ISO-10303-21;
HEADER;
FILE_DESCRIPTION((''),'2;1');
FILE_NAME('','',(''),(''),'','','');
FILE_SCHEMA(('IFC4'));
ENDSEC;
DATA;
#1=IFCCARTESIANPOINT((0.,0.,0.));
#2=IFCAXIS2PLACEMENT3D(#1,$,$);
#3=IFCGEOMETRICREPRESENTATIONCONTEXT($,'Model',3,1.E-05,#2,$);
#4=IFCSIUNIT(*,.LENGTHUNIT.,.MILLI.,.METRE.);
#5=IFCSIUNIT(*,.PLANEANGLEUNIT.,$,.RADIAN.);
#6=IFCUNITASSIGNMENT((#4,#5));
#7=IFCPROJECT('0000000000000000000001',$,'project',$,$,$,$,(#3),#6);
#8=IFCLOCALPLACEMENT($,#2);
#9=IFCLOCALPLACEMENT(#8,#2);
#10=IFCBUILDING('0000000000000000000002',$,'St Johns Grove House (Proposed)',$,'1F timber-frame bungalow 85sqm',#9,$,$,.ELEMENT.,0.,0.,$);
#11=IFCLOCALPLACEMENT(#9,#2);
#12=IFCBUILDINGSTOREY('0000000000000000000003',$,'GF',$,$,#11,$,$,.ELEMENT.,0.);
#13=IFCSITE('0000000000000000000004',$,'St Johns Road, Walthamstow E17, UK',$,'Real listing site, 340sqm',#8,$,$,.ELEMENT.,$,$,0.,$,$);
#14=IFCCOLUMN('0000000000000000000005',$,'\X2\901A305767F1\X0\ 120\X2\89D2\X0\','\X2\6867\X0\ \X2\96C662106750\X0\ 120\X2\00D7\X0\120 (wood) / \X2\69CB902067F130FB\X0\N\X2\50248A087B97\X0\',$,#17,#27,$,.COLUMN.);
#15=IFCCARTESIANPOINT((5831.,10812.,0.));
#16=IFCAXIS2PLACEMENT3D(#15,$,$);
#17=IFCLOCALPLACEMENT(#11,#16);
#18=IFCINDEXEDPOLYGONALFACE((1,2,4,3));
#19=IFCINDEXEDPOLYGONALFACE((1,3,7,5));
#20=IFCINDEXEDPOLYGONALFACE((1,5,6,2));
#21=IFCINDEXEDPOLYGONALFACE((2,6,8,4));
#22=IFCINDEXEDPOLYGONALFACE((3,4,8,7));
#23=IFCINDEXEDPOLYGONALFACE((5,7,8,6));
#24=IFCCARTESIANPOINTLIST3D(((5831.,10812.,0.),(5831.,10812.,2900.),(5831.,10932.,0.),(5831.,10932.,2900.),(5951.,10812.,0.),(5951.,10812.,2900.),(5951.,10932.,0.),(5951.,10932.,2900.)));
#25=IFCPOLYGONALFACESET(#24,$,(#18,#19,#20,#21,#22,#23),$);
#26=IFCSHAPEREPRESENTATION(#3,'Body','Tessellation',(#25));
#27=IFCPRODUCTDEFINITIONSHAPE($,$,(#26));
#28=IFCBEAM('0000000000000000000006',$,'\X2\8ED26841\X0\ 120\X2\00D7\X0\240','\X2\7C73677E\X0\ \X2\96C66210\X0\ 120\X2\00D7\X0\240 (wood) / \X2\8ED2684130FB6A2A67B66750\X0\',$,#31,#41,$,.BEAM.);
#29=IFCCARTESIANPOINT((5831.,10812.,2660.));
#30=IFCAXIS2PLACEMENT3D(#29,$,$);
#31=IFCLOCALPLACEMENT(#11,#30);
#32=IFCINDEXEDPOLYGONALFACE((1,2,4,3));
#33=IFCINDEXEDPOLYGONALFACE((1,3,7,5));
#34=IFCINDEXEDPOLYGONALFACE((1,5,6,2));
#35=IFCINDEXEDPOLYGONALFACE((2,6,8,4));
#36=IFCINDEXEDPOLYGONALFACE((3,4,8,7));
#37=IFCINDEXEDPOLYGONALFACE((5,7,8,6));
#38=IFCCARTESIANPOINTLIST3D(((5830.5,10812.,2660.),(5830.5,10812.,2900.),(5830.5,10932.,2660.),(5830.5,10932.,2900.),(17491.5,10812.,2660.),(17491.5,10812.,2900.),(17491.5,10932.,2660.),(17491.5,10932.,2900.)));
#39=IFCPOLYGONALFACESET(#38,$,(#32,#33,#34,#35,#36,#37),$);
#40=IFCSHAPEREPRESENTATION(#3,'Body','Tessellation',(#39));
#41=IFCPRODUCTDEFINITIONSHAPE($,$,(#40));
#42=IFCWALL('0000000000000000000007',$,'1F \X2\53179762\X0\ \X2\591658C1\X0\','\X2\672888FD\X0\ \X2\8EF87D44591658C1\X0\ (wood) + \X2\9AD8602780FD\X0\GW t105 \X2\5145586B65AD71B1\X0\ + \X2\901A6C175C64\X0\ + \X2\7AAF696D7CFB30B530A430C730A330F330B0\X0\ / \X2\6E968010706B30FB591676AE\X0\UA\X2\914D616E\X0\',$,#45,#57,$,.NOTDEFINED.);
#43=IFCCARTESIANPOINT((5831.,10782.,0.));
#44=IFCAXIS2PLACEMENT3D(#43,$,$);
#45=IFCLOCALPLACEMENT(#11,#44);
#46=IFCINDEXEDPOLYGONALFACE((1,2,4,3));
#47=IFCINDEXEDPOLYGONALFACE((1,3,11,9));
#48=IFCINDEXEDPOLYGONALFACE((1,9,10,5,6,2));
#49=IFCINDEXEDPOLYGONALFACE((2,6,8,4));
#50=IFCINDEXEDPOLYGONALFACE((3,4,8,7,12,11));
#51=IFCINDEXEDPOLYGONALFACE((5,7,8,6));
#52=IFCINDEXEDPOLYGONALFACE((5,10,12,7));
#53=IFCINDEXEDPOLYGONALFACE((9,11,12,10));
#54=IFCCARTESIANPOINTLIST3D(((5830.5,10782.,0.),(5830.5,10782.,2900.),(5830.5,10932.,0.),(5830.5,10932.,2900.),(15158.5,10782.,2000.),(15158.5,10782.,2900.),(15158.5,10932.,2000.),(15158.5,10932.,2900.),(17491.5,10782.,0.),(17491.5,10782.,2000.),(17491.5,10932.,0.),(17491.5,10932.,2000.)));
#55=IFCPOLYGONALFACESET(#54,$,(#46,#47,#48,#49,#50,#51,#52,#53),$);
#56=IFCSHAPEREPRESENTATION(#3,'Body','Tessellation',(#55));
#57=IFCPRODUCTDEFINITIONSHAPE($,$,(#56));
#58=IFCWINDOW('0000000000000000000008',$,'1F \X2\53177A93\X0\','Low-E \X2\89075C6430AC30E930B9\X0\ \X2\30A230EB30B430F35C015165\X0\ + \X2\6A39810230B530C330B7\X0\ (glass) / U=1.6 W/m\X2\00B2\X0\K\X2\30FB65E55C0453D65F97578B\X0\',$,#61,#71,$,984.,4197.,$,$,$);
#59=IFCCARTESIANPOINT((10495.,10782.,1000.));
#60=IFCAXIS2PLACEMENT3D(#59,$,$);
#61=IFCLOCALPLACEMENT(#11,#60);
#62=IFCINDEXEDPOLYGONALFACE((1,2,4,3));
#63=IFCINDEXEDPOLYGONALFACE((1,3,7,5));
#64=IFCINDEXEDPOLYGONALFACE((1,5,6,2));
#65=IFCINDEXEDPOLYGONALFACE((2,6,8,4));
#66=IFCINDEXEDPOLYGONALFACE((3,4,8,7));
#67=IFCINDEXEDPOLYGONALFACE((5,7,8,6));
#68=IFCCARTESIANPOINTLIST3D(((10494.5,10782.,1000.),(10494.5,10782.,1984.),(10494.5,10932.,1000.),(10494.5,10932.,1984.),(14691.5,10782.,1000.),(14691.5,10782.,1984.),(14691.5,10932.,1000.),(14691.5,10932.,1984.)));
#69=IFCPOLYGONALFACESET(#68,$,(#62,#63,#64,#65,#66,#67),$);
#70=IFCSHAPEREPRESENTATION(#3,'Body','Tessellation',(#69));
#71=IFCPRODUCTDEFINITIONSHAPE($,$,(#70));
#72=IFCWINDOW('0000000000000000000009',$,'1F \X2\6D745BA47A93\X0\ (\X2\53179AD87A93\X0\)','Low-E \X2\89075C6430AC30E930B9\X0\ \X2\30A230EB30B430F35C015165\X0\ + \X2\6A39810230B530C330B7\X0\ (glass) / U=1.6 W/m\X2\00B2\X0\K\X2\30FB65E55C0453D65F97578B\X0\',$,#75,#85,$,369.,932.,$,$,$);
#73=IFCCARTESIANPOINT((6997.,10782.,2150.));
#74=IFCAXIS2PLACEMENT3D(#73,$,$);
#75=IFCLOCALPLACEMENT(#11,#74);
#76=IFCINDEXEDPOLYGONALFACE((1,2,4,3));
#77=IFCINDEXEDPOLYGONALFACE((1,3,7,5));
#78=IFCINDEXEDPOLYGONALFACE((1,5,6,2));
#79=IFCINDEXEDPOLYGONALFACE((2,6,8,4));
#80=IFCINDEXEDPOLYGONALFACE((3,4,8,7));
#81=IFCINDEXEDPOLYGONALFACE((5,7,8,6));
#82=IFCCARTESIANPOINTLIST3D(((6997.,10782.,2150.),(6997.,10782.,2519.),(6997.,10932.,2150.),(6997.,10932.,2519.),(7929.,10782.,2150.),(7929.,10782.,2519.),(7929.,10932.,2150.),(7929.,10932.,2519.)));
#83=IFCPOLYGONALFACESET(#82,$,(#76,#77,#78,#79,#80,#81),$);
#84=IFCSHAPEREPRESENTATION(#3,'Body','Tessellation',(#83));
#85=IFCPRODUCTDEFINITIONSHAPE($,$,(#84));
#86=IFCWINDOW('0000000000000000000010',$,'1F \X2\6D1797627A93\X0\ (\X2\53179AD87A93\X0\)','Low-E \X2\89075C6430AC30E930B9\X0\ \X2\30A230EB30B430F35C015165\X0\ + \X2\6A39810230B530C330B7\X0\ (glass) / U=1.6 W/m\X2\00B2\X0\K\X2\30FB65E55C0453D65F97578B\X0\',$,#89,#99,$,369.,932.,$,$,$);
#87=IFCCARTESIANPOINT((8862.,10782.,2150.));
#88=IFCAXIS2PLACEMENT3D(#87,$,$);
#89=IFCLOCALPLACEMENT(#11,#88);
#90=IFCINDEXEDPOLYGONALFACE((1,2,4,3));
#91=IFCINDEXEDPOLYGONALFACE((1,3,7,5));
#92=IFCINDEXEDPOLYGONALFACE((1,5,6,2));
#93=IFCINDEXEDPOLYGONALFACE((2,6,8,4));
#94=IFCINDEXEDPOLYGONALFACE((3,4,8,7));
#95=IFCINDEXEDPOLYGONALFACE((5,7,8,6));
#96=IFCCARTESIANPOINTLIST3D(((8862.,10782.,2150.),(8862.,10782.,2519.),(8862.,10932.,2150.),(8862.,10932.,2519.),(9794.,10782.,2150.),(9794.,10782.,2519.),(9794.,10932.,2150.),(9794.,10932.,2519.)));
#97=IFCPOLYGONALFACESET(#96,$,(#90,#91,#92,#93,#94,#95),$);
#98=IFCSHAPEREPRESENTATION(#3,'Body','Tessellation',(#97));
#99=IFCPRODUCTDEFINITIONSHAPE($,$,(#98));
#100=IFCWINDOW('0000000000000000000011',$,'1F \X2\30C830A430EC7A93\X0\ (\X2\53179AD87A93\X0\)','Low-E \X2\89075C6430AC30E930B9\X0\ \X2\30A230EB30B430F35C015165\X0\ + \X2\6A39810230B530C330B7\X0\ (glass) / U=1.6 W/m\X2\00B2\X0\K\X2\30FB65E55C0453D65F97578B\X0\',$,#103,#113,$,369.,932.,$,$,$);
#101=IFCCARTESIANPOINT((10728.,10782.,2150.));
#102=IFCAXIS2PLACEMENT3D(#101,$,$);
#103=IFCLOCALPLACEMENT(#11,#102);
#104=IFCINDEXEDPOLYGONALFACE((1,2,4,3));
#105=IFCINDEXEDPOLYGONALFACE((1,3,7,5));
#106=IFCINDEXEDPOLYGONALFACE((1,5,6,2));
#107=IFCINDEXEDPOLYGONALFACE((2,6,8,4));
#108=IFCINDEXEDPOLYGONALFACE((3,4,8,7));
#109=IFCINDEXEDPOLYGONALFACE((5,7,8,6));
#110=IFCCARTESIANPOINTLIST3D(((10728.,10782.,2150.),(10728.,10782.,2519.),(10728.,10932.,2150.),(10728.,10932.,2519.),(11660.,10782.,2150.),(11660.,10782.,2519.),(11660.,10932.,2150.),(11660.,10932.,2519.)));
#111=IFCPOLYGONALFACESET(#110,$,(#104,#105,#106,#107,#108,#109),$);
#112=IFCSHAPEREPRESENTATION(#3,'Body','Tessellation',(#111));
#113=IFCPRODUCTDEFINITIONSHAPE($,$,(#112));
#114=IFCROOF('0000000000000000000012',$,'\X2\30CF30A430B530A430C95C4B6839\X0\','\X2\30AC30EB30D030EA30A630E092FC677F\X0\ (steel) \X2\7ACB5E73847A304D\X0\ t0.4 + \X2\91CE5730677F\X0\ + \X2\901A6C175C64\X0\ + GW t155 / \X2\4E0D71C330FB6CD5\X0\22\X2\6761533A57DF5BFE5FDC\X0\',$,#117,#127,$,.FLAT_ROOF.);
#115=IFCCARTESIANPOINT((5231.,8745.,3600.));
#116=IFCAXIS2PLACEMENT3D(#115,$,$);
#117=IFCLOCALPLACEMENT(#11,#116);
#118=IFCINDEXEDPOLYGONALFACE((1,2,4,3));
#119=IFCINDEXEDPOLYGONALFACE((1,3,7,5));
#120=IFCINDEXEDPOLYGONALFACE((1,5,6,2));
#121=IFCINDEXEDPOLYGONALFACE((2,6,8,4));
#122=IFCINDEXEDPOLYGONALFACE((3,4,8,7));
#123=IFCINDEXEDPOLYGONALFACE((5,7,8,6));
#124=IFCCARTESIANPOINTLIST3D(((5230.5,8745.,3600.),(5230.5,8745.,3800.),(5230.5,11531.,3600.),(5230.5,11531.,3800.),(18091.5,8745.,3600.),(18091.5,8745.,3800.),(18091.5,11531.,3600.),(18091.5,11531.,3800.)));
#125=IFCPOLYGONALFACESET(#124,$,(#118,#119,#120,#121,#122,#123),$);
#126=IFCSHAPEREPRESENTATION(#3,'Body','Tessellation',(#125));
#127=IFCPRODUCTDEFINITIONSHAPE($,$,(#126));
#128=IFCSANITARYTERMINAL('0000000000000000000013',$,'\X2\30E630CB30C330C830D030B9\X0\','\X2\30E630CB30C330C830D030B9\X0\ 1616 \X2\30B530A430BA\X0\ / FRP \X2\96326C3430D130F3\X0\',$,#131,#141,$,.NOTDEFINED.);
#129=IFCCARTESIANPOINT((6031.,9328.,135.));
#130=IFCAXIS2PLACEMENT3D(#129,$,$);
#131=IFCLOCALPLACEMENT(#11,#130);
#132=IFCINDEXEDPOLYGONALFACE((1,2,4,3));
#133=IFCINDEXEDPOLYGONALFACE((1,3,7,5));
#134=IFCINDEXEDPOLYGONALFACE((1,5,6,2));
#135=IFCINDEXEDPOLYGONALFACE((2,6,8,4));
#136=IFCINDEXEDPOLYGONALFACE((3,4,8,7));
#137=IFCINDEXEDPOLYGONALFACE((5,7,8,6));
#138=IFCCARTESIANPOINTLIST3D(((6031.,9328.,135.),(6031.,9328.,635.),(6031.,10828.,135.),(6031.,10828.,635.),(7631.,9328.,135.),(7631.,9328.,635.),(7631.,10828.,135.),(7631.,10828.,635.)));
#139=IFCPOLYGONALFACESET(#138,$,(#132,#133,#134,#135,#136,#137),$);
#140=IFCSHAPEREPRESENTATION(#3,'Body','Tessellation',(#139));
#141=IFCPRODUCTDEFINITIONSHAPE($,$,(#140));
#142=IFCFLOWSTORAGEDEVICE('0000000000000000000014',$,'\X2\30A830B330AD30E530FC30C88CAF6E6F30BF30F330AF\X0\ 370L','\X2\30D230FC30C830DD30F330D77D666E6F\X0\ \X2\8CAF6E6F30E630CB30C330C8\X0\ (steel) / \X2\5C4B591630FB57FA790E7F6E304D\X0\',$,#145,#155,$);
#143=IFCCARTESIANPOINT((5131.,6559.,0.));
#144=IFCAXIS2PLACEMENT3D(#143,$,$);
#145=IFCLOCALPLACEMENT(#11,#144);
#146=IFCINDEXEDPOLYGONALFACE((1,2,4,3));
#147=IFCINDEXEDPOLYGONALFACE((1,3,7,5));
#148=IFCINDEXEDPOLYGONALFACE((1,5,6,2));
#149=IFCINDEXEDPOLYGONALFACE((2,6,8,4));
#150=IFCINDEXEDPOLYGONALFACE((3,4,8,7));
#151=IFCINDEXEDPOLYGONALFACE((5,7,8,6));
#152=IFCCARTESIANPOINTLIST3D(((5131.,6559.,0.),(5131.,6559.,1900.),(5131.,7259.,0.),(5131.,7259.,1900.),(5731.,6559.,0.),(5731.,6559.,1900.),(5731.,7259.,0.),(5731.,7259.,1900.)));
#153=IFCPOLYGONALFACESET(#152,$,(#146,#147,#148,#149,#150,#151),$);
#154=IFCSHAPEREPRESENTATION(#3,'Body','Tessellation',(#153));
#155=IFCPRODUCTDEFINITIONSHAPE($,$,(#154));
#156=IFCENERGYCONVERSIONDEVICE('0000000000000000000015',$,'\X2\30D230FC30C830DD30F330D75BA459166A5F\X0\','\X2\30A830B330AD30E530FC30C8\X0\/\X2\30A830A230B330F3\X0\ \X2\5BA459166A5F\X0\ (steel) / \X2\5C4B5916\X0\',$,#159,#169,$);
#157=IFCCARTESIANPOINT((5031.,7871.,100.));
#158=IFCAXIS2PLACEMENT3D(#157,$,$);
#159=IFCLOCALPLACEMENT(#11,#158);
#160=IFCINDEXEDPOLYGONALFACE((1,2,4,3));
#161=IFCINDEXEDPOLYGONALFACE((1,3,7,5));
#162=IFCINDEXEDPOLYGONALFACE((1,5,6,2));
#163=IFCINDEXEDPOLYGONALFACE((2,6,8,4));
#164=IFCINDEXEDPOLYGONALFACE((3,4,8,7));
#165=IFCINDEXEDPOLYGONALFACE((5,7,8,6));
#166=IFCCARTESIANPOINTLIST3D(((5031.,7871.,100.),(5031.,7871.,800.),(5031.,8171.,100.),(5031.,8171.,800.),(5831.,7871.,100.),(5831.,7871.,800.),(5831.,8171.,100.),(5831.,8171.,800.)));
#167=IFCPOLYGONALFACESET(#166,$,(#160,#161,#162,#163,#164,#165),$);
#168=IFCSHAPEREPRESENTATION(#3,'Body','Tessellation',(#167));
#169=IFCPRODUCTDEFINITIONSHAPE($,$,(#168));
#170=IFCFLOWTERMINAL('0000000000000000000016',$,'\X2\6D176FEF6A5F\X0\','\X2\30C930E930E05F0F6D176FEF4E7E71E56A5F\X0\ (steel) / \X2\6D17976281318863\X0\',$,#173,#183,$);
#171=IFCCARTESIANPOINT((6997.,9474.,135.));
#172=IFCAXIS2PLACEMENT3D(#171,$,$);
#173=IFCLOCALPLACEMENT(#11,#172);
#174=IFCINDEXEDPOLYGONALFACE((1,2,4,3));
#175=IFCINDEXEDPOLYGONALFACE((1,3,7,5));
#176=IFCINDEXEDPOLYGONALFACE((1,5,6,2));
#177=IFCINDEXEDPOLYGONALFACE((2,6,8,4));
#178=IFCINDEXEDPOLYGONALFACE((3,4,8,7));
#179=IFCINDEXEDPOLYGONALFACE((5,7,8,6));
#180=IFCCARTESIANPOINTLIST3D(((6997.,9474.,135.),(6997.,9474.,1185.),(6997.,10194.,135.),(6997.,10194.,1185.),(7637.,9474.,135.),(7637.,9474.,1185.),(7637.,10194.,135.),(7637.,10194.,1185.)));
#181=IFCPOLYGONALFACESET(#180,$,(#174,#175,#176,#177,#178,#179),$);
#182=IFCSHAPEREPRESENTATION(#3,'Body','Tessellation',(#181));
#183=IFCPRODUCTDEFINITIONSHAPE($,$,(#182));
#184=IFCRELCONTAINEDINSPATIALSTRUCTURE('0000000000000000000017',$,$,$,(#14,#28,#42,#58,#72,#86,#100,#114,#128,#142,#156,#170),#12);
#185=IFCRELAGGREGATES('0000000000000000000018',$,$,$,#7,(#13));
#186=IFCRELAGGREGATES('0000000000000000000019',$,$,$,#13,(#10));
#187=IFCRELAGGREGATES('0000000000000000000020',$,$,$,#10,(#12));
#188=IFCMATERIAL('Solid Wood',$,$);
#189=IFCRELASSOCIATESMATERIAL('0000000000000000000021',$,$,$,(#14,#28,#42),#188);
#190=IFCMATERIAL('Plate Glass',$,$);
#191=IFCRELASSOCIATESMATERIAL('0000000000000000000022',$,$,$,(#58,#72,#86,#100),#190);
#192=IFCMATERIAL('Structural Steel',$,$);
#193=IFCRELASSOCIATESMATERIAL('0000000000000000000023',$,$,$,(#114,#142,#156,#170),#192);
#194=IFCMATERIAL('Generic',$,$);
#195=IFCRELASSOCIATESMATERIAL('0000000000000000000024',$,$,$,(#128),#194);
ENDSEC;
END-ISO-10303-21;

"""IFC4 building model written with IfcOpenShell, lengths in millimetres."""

from ifc_helpers import new_model, si_unit, frame, frame_2d, origin, place, context, project, spatial, rectangle, extrude, material, element, fill, save


model = new_model("IFC4")

# Units and contexts
model_context = context("Model", 3, precision=1e-05, world=origin())
ifc_project = project(units=[si_unit("LENGTHUNIT", "METRE", prefix="MILLI"), si_unit("PLANEANGLEUNIT", "RADIAN")], contexts=[model_context])

# Site, building, storey
site_placement = place(None, origin())
site = spatial("IfcSite", under=ifc_project, at=site_placement, Name="St Johns Road, Walthamstow E17, UK", ObjectType="Real listing site, 340sqm", CompositionType="ELEMENT", RefElevation=0.0)
building_placement = place(site_placement, origin())
building = spatial("IfcBuilding", under=site, at=building_placement, Name="St Johns Grove House (Proposed)", ObjectType="1F timber-frame bungalow 85sqm", CompositionType="ELEMENT", ElevationOfRefHeight=0.0, ElevationOfTerrain=0.0)
storey_placement = place(building_placement, origin())
storey = spatial("IfcBuildingStorey", under=building, at=storey_placement, Name="GF", CompositionType="ELEMENT", Elevation=0.0)

# Column
ifc_material_1 = material(Name="Solid Wood")
column_1_placement = place(storey_placement, frame((5831.0, 10812.0, 0.0)))
element("IfcColumn", 1, at=column_1_placement, inside=storey, material=ifc_material_1, Name="通し柱 120角", Description="桧 集成材 120×120 (wood) / 構造柱・N値計算", PredefinedType="COLUMN", context=model_context, shape_type="SweptSolid", body=[
    extrude(rectangle(XDim=120.0, YDim=120.0, at=frame_2d((60.0, 60.0))), frame((5831.0, 10812.0, 0.0)), (0.0, 0.0, 1.0), 2900.0),
])

# Beam
beam_1_placement = place(storey_placement, frame((5831.0, 10812.0, 2660.0)))
element("IfcBeam", 2, at=beam_1_placement, inside=storey, material=ifc_material_1, Name="軒桁 120×240", Description="米松 集成 120×240 (wood) / 軒桁・横架材", PredefinedType="BEAM", context=model_context, shape_type="SweptSolid", body=[
    extrude(rectangle(XDim=11661.0, YDim=120.0, at=frame_2d((5830.0, 60.0))), frame((5831.0, 10812.0, 2660.0)), (0.0, 0.0, 1.0), 240.0),
])

# Wall, openings, windows
wall_1_placement = place(storey_placement, frame((5831.0, 10782.0, 0.0)))
wall_1 = element("IfcWall", 3, at=wall_1_placement, inside=storey, material=ifc_material_1, Name="1F 北面 外壁", Description="木製 軸組外壁 (wood) + 高性能GW t105 充填断熱 + 通気層 + 窯業系サイディング / 準耐火・外皮UA配慮", PredefinedType="NOTDEFINED", context=model_context, shape_type="SweptSolid", body=[
    extrude(rectangle(XDim=11661.0, YDim=150.0, at=frame_2d((5830.0, 75.0))), frame((5831.0, 10782.0, 0.0)), (0.0, 0.0, 1.0), 2900.0),
])
opening_1_placement = place(storey_placement, frame((10495.0, 10782.0, 1000.0)))
opening_1 = element("IfcOpeningElement", 4, at=opening_1_placement, cuts=wall_1, PredefinedType="NOTDEFINED", context=model_context, shape_type="SweptSolid", body=[
    extrude(rectangle(XDim=4197.0, YDim=150.0, at=frame_2d((2098.0, 75.0))), frame((10495.0, 10782.0, 1000.0)), (0.0, 0.0, 1.0), 984.0),
])
opening_2_placement = place(storey_placement, frame((6997.0, 10782.0, 2150.0)))
opening_2 = element("IfcOpeningElement", 5, at=opening_2_placement, cuts=wall_1, PredefinedType="NOTDEFINED", context=model_context, shape_type="SweptSolid", body=[
    extrude(rectangle(XDim=932.0, YDim=150.0, at=frame_2d((466.0, 75.0))), frame((6997.0, 10782.0, 2150.0)), (0.0, 0.0, 1.0), 369.0),
])
opening_3_placement = place(storey_placement, frame((8862.0, 10782.0, 2150.0)))
opening_3 = element("IfcOpeningElement", 6, at=opening_3_placement, cuts=wall_1, PredefinedType="NOTDEFINED", context=model_context, shape_type="SweptSolid", body=[
    extrude(rectangle(XDim=932.0, YDim=150.0, at=frame_2d((466.0, 75.0))), frame((8862.0, 10782.0, 2150.0)), (0.0, 0.0, 1.0), 369.0),
])
opening_4_placement = place(storey_placement, frame((10728.0, 10782.0, 2150.0)))
opening_4 = element("IfcOpeningElement", 7, at=opening_4_placement, cuts=wall_1, PredefinedType="NOTDEFINED", context=model_context, shape_type="SweptSolid", body=[
    extrude(rectangle(XDim=932.0, YDim=150.0, at=frame_2d((466.0, 75.0))), frame((10728.0, 10782.0, 2150.0)), (0.0, 0.0, 1.0), 369.0),
])
ifc_material_2 = material(Name="Plate Glass")
window_1_placement = place(storey_placement, frame((10495.0, 10782.0, 1000.0)))
window_1 = element("IfcWindow", 8, at=window_1_placement, inside=storey, material=ifc_material_2, Name="1F 北窓", Description="Low-E 複層ガラス アルゴン封入 + 樹脂サッシ (glass) / U=1.6 W/m²K・日射取得型", OverallHeight=984.0, OverallWidth=4197.0, context=model_context, shape_type="SweptSolid", body=[
    extrude(rectangle(XDim=4197.0, YDim=150.0, at=frame_2d((2098.0, 75.0))), frame((10495.0, 10782.0, 1000.0)), (0.0, 0.0, 1.0), 984.0),
])
fill(opening_1, window_1)
window_2_placement = place(storey_placement, frame((6997.0, 10782.0, 2150.0)))
window_2 = element("IfcWindow", 9, at=window_2_placement, inside=storey, material=ifc_material_2, Name="1F 浴室窓 (北高窓)", Description="Low-E 複層ガラス アルゴン封入 + 樹脂サッシ (glass) / U=1.6 W/m²K・日射取得型", OverallHeight=369.0, OverallWidth=932.0, context=model_context, shape_type="SweptSolid", body=[
    extrude(rectangle(XDim=932.0, YDim=150.0, at=frame_2d((466.0, 75.0))), frame((6997.0, 10782.0, 2150.0)), (0.0, 0.0, 1.0), 369.0),
])
fill(opening_2, window_2)
window_3_placement = place(storey_placement, frame((8862.0, 10782.0, 2150.0)))
window_3 = element("IfcWindow", 10, at=window_3_placement, inside=storey, material=ifc_material_2, Name="1F 洗面窓 (北高窓)", Description="Low-E 複層ガラス アルゴン封入 + 樹脂サッシ (glass) / U=1.6 W/m²K・日射取得型", OverallHeight=369.0, OverallWidth=932.0, context=model_context, shape_type="SweptSolid", body=[
    extrude(rectangle(XDim=932.0, YDim=150.0, at=frame_2d((466.0, 75.0))), frame((8862.0, 10782.0, 2150.0)), (0.0, 0.0, 1.0), 369.0),
])
fill(opening_3, window_3)
window_4_placement = place(storey_placement, frame((10728.0, 10782.0, 2150.0)))
window_4 = element("IfcWindow", 11, at=window_4_placement, inside=storey, material=ifc_material_2, Name="1F トイレ窓 (北高窓)", Description="Low-E 複層ガラス アルゴン封入 + 樹脂サッシ (glass) / U=1.6 W/m²K・日射取得型", OverallHeight=369.0, OverallWidth=932.0, context=model_context, shape_type="SweptSolid", body=[
    extrude(rectangle(XDim=932.0, YDim=150.0, at=frame_2d((466.0, 75.0))), frame((10728.0, 10782.0, 2150.0)), (0.0, 0.0, 1.0), 369.0),
])
fill(opening_4, window_4)

# Roof
ifc_material_3 = material(Name="Structural Steel")
roof_placement = place(storey_placement, frame((5231.0, 8745.0, 3600.0)))
element("IfcRoof", 12, at=roof_placement, inside=storey, material=ifc_material_3, Name="ハイサイド屋根", Description="ガルバリウム鋼板 (steel) 立平葺き t0.4 + 野地板 + 通気層 + GW t155 / 不燃・法22条区域対応", PredefinedType="FLAT_ROOF", context=model_context, shape_type="SweptSolid", body=[
    extrude(rectangle(XDim=12861.0, YDim=2786.0, at=frame_2d((6430.0, 1393.0))), frame((5231.0, 8745.0, 3600.0)), (0.0, 0.0, 1.0), 200.0),
])

# Sanitary terminal
ifc_material_4 = material(Name="Generic")
sanitary_terminal_placement = place(storey_placement, frame((6031.0, 9328.0, 135.0)))
element("IfcSanitaryTerminal", 13, at=sanitary_terminal_placement, inside=storey, material=ifc_material_4, Name="ユニットバス", Description="ユニットバス 1616 サイズ / FRP 防水パン", PredefinedType="NOTDEFINED", context=model_context, shape_type="SweptSolid", body=[
    extrude(rectangle(XDim=1600.0, YDim=1500.0, at=frame_2d((800.0, 750.0))), frame((6031.0, 9328.0, 135.0)), (0.0, 0.0, 1.0), 500.0),
])

# Flow storage device
flow_storage_device_placement = place(storey_placement, frame((5131.0, 6559.0, 0.0)))
element("IfcFlowStorageDevice", 14, at=flow_storage_device_placement, inside=storey, material=ifc_material_3, Name="エコキュート貯湯タンク 370L", Description="ヒートポンプ給湯 貯湯ユニット (steel) / 屋外・基礎置き", context=model_context, shape_type="SweptSolid", body=[
    extrude(rectangle(XDim=600.0, YDim=700.0, at=frame_2d((300.0, 350.0))), frame((5131.0, 6559.0, 0.0)), (0.0, 0.0, 1.0), 1900.0),
])

# Energy conversion device
energy_conversion_device_placement = place(storey_placement, frame((5031.0, 7871.0, 100.0)))
element("IfcEnergyConversionDevice", 15, at=energy_conversion_device_placement, inside=storey, material=ifc_material_3, Name="ヒートポンプ室外機", Description="エコキュート/エアコン 室外機 (steel) / 屋外", context=model_context, shape_type="SweptSolid", body=[
    extrude(rectangle(XDim=800.0, YDim=300.0, at=frame_2d((400.0, 150.0))), frame((5031.0, 7871.0, 100.0)), (0.0, 0.0, 1.0), 700.0),
])

# Flow terminal
flow_terminal_placement = place(storey_placement, frame((6997.0, 9474.0, 135.0)))
element("IfcFlowTerminal", 16, at=flow_terminal_placement, inside=storey, material=ifc_material_3, Name="洗濯機", Description="ドラム式洗濯乾燥機 (steel) / 洗面脱衣", context=model_context, shape_type="SweptSolid", body=[
    extrude(rectangle(XDim=640.0, YDim=720.0, at=frame_2d((320.0, 360.0))), frame((6997.0, 9474.0, 135.0)), (0.0, 0.0, 1.0), 1050.0),
])

save(model, "model.ifc")
